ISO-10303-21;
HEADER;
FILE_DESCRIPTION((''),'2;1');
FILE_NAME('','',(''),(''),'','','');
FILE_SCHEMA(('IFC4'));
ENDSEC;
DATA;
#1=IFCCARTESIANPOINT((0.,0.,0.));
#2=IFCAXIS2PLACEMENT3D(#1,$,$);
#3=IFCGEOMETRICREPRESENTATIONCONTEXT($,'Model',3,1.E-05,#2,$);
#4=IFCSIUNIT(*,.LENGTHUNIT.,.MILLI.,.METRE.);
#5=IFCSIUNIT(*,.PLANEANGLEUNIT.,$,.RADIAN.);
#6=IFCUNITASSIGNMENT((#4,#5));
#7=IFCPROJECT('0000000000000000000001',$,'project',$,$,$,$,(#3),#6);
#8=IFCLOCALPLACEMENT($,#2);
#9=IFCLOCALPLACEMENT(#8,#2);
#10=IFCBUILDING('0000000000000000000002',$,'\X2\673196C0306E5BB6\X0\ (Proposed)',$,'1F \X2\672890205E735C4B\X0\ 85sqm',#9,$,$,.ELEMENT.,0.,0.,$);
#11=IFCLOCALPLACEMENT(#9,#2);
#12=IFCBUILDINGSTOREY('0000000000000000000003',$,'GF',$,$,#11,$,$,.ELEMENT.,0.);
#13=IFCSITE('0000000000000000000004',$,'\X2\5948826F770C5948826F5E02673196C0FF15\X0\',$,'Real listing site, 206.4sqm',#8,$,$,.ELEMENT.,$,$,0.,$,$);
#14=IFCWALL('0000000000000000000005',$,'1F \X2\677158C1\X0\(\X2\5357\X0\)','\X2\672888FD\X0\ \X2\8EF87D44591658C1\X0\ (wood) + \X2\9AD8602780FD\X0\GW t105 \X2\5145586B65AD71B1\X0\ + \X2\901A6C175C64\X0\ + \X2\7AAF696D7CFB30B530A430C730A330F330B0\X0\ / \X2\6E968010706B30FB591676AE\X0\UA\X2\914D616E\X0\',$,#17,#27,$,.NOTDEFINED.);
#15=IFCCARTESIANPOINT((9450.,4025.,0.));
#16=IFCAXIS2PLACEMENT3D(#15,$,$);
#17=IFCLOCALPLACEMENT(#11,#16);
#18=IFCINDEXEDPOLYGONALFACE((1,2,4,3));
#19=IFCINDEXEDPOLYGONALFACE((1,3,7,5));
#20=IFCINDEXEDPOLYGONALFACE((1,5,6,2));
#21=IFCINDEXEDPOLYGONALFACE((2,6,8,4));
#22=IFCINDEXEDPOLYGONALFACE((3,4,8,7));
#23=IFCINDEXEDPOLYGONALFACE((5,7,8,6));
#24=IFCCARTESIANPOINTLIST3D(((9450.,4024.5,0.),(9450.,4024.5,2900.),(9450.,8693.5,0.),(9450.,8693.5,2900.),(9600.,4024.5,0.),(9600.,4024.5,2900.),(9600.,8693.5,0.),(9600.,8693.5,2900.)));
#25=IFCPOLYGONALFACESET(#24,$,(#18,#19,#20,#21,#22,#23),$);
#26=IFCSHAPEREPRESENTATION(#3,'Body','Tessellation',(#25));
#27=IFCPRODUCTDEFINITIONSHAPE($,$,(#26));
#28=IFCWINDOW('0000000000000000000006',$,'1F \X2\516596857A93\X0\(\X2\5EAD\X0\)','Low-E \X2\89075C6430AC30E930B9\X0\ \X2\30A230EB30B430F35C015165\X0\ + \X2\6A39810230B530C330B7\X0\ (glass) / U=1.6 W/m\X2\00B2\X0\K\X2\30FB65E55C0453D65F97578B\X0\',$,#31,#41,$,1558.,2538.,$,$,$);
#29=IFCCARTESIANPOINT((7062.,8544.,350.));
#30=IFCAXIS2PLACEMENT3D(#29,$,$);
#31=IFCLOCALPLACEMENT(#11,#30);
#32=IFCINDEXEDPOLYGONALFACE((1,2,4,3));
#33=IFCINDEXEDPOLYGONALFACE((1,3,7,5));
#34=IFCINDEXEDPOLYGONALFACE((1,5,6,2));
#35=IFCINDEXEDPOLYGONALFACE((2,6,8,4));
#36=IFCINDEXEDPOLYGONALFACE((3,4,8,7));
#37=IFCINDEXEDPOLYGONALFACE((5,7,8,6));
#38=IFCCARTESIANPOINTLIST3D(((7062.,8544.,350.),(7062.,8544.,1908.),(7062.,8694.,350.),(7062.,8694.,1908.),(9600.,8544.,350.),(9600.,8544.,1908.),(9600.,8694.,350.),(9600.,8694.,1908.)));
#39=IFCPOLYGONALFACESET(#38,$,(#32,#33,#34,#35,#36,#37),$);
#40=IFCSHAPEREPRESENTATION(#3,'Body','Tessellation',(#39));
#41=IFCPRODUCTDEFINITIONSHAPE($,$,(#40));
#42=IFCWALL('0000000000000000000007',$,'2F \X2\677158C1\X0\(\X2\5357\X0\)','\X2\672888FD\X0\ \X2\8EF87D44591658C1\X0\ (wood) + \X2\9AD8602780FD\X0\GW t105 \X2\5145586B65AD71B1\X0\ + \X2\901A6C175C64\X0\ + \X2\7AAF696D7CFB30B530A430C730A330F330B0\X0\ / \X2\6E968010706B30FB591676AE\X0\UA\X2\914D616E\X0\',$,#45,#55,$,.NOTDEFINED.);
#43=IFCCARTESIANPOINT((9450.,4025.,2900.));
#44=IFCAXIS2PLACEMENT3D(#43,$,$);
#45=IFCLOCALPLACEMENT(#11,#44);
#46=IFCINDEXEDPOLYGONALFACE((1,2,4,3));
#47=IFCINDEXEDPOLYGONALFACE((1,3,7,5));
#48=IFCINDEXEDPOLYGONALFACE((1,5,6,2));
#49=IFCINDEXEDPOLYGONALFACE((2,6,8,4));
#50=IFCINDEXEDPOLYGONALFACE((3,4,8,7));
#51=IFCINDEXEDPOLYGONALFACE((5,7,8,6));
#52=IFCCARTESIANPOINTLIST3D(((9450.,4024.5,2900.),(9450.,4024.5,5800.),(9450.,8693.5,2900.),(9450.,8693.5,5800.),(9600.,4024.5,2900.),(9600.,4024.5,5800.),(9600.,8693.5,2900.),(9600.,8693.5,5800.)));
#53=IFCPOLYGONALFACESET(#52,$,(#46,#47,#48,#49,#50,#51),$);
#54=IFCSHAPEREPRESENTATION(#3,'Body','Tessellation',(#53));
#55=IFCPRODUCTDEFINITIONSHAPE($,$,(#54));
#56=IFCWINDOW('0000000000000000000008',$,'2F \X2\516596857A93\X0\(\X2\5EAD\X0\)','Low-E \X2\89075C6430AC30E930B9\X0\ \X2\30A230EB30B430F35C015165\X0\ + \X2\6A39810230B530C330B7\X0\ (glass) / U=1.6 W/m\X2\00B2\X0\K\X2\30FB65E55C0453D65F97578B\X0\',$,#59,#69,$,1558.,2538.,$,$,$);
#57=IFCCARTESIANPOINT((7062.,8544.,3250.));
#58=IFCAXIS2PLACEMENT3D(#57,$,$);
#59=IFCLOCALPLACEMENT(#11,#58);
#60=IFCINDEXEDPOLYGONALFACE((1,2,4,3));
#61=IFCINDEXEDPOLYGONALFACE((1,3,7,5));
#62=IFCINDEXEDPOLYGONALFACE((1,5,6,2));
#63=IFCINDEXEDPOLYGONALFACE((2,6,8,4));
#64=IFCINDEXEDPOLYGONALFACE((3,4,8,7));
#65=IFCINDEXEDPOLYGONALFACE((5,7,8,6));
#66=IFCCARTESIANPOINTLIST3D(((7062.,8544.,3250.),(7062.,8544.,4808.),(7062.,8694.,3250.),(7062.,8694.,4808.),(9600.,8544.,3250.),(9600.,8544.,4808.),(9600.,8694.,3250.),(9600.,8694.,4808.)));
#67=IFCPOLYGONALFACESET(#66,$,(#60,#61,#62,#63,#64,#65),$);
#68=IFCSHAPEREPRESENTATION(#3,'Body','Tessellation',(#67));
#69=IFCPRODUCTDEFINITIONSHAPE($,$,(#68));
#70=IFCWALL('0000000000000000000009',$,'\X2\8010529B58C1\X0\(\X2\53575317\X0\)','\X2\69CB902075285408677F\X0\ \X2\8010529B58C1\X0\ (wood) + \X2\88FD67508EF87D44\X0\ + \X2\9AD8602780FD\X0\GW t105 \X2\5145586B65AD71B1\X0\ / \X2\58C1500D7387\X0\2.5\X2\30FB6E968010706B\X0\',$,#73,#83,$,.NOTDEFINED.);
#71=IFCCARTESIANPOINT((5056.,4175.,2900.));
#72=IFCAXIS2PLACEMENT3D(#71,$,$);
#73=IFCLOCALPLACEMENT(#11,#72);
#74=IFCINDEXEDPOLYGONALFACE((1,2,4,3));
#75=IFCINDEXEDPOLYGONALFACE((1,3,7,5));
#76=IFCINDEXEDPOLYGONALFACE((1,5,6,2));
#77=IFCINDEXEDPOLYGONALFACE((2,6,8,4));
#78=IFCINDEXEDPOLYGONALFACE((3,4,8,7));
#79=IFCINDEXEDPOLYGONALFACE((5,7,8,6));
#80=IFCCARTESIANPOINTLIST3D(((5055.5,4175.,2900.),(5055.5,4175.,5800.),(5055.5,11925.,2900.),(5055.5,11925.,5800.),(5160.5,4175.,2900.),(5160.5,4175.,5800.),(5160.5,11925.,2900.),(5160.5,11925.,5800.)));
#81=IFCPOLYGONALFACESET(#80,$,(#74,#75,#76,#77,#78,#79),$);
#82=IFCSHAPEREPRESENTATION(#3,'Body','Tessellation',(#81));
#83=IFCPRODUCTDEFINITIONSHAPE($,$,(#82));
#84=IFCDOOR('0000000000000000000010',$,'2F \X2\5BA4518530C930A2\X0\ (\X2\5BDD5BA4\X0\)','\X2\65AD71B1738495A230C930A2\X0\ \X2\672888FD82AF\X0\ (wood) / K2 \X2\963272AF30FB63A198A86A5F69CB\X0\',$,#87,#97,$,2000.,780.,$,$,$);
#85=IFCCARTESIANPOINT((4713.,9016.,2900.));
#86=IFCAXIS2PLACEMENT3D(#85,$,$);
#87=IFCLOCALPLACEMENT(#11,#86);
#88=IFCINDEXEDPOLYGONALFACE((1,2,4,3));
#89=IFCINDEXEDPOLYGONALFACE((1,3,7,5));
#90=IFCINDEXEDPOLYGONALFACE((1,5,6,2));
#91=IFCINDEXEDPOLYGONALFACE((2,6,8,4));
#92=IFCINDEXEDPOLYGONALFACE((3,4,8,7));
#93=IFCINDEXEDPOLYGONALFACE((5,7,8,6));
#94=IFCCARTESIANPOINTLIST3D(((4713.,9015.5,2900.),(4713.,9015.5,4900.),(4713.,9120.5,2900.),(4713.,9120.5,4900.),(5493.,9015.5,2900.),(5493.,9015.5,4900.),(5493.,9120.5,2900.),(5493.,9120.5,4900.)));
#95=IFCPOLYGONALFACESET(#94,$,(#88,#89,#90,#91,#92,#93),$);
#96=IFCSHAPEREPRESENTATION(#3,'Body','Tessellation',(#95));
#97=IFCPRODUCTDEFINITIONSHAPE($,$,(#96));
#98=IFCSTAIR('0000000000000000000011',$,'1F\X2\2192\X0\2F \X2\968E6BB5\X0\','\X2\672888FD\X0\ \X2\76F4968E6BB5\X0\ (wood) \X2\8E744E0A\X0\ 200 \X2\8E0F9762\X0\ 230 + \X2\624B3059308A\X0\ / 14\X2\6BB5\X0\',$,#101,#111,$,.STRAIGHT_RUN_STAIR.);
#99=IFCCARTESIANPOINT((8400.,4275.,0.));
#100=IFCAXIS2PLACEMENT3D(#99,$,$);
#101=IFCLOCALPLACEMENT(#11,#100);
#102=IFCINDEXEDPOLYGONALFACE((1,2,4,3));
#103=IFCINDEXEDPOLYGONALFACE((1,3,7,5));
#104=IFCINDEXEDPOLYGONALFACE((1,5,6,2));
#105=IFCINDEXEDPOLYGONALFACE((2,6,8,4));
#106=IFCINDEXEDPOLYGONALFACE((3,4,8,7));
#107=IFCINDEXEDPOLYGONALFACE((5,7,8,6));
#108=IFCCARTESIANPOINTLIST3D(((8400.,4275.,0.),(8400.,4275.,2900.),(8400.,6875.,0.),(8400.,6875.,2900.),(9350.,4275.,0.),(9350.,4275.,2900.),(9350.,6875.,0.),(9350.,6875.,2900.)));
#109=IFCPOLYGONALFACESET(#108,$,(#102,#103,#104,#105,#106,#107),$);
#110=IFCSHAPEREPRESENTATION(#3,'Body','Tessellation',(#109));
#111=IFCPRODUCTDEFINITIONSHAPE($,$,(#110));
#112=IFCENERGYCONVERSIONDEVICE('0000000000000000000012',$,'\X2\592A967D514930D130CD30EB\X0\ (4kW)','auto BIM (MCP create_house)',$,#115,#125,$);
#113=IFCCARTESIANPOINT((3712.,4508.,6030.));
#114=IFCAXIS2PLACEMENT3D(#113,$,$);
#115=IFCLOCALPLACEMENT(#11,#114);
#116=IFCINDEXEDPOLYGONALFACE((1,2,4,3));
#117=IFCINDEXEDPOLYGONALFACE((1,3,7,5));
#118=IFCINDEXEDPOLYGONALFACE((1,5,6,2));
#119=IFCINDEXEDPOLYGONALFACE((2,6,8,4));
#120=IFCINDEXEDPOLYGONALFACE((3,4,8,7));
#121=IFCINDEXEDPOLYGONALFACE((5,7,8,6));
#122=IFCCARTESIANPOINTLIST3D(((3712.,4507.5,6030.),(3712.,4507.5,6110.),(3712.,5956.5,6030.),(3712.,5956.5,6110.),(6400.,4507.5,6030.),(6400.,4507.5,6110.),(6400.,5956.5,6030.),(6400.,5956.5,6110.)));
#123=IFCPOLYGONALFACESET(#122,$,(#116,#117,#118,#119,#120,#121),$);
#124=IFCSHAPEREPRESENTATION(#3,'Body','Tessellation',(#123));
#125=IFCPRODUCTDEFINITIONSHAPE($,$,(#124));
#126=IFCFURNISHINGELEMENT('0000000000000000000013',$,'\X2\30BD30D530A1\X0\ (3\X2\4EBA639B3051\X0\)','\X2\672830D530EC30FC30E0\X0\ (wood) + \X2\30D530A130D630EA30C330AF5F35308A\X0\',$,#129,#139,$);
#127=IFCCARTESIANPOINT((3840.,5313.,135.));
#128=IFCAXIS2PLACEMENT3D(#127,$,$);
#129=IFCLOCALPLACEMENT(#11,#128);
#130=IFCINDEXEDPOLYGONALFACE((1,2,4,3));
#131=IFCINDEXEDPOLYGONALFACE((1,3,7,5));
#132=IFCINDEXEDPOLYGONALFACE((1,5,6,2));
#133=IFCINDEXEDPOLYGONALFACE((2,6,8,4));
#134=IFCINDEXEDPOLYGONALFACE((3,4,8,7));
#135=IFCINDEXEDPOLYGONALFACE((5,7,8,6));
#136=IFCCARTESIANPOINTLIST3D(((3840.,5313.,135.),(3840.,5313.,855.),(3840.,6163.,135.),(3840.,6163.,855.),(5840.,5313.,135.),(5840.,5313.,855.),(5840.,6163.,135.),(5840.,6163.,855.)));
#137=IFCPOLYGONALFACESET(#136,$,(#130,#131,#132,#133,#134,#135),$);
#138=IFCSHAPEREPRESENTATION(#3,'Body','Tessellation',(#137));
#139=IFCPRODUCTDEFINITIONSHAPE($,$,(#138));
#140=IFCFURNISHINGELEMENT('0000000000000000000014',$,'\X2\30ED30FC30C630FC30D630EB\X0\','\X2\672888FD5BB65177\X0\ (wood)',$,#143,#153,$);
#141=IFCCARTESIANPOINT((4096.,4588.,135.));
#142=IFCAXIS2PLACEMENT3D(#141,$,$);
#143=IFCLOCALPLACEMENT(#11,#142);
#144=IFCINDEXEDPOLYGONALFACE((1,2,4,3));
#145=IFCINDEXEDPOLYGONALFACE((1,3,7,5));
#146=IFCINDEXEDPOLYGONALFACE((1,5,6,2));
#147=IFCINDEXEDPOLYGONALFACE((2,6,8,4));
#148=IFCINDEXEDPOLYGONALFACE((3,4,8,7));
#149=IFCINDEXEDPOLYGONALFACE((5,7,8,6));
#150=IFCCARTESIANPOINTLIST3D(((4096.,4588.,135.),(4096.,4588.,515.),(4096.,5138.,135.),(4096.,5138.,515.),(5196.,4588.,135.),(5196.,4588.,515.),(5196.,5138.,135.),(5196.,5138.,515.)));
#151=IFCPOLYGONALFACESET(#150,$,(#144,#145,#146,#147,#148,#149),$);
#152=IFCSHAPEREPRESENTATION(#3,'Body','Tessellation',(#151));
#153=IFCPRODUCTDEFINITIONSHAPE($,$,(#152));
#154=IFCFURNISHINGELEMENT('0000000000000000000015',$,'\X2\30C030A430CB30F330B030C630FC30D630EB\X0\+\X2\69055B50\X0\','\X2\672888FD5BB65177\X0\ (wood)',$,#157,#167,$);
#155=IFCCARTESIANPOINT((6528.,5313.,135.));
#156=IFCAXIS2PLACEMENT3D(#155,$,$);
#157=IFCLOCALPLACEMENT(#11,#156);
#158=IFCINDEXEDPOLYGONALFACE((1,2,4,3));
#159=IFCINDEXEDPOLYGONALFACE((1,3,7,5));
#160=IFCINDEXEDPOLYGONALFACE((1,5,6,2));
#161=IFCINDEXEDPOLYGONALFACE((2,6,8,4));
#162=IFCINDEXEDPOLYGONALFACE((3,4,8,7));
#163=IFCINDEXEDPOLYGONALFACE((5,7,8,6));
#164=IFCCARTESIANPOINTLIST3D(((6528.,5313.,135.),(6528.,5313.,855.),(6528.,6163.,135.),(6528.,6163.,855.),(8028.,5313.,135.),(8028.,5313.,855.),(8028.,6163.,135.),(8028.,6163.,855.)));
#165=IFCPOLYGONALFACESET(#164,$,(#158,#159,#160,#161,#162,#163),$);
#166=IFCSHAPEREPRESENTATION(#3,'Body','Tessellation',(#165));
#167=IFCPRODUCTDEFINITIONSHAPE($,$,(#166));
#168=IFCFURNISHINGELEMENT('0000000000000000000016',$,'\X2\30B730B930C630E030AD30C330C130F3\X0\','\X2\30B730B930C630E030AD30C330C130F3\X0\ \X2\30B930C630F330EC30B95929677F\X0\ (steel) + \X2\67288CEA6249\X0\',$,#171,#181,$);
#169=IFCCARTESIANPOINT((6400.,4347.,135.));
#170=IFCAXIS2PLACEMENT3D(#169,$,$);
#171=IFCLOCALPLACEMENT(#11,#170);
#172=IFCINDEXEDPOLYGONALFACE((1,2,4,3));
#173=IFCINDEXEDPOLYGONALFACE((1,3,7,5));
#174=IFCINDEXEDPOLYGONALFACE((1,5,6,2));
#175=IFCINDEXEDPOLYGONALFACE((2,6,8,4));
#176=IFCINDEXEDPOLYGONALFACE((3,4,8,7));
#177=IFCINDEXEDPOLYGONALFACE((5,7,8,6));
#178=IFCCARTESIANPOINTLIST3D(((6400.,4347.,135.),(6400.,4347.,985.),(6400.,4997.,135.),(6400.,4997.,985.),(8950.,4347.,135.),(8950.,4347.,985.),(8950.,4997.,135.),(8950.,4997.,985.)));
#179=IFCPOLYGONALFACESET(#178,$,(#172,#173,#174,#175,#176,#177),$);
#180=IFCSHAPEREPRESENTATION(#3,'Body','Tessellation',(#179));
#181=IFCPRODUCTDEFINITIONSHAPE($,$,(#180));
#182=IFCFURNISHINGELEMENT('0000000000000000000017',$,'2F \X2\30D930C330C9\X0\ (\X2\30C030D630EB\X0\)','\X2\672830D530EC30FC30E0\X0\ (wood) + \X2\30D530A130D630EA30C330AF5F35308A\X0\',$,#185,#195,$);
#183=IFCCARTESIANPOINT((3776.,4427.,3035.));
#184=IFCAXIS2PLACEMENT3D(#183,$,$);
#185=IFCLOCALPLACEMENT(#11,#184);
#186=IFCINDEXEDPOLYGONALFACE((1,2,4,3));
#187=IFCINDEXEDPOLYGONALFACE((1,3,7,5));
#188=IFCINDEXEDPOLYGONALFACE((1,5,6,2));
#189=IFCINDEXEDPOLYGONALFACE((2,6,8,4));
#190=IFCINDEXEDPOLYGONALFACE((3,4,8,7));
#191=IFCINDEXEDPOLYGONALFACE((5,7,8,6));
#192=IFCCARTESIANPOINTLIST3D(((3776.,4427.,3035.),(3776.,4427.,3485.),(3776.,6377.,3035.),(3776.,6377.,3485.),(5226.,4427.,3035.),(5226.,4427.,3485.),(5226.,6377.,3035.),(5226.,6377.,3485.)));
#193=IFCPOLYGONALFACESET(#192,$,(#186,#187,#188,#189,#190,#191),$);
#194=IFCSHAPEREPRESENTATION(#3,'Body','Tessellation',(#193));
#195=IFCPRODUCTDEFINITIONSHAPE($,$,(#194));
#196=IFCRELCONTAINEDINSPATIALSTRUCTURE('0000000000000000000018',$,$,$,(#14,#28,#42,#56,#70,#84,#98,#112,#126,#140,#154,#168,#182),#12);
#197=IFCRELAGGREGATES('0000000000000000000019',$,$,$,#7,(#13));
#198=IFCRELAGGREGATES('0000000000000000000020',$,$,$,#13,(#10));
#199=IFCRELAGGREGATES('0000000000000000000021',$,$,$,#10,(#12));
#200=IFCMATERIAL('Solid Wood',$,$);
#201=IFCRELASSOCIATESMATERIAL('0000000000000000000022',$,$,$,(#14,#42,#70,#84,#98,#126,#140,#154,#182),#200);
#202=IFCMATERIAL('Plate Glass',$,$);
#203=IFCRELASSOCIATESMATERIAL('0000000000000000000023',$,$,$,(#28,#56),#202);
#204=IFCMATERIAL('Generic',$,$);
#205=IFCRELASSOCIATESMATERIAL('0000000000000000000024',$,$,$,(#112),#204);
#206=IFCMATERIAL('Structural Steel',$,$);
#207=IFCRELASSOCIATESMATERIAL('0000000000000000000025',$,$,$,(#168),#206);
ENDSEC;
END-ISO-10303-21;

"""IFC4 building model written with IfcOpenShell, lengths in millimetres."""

from ifc_helpers import new_model, si_unit, frame, frame_2d, origin, place, context, project, spatial, rectangle, extrude, material, element, fill, save


model = new_model("IFC4")

# Units and contexts
model_context = context("Model", 3, precision=1e-05, world=origin())
ifc_project = project(units=[si_unit("LENGTHUNIT", "METRE", prefix="MILLI"), si_unit("PLANEANGLEUNIT", "RADIAN")], contexts=[model_context])

# Site, building, storey
site_placement = place(None, origin())
site = spatial("IfcSite", under=ifc_project, at=site_placement, Name="奈良県奈良市朱雀５", ObjectType="Real listing site, 206.4sqm", CompositionType="ELEMENT", RefElevation=0.0)
building_placement = place(site_placement, origin())
building = spatial("IfcBuilding", under=site, at=building_placement, Name="朱雀の家 (Proposed)", ObjectType="1F 木造平屋 85sqm", CompositionType="ELEMENT", ElevationOfRefHeight=0.0, ElevationOfTerrain=0.0)
storey_placement = place(building_placement, origin())
storey = spatial("IfcBuildingStorey", under=building, at=storey_placement, Name="GF", CompositionType="ELEMENT", Elevation=0.0)

# Wall, opening, window
ifc_material_1 = material(Name="Solid Wood")
wall_1_placement = place(storey_placement, frame((9450.0, 4025.0, 0.0)))
wall_1 = element("IfcWall", 1, at=wall_1_placement, inside=storey, material=ifc_material_1, Name="1F 東壁(南)", Description="木製 軸組外壁 (wood) + 高性能GW t105 充填断熱 + 通気層 + 窯業系サイディング / 準耐火・外皮UA配慮", PredefinedType="NOTDEFINED", context=model_context, shape_type="SweptSolid", body=[
    extrude(rectangle(XDim=150.0, YDim=4669.0, at=frame_2d((75.0, 2334.0))), frame((9450.0, 4025.0, 0.0)), (0.0, 0.0, 1.0), 2900.0),
])
opening_1_placement = place(storey_placement, frame((7062.0, 8544.0, 350.0)))
opening_1 = element("IfcOpeningElement", 2, at=opening_1_placement, cuts=wall_1, PredefinedType="NOTDEFINED", context=model_context, shape_type="SweptSolid", body=[
    extrude(rectangle(XDim=2538.0, YDim=150.0, at=frame_2d((1269.0, 75.0))), frame((7062.0, 8544.0, 350.0)), (0.0, 0.0, 1.0), 1558.0),
])
ifc_material_2 = material(Name="Plate Glass")
window_1_placement = place(storey_placement, frame((7062.0, 8544.0, 350.0)))
window_1 = element("IfcWindow", 3, at=window_1_placement, inside=storey, material=ifc_material_2, Name="1F 入隅窓(庭)", Description="Low-E 複層ガラス アルゴン封入 + 樹脂サッシ (glass) / U=1.6 W/m²K・日射取得型", OverallHeight=1558.0, OverallWidth=2538.0, context=model_context, shape_type="SweptSolid", body=[
    extrude(rectangle(XDim=2538.0, YDim=150.0, at=frame_2d((1269.0, 75.0))), frame((7062.0, 8544.0, 350.0)), (0.0, 0.0, 1.0), 1558.0),
])
fill(opening_1, window_1)

# Wall, opening, window
wall_2_placement = place(storey_placement, frame((9450.0, 4025.0, 2900.0)))
wall_2 = element("IfcWall", 4, at=wall_2_placement, inside=storey, material=ifc_material_1, Name="2F 東壁(南)", Description="木製 軸組外壁 (wood) + 高性能GW t105 充填断熱 + 通気層 + 窯業系サイディング / 準耐火・外皮UA配慮", PredefinedType="NOTDEFINED", context=model_context, shape_type="SweptSolid", body=[
    extrude(rectangle(XDim=150.0, YDim=4669.0, at=frame_2d((75.0, 2334.0))), frame((9450.0, 4025.0, 2900.0)), (0.0, 0.0, 1.0), 2900.0),
])
opening_2_placement = place(storey_placement, frame((7062.0, 8544.0, 3250.0)))
opening_2 = element("IfcOpeningElement", 5, at=opening_2_placement, cuts=wall_2, PredefinedType="NOTDEFINED", context=model_context, shape_type="SweptSolid", body=[
    extrude(rectangle(XDim=2538.0, YDim=150.0, at=frame_2d((1269.0, 75.0))), frame((7062.0, 8544.0, 3250.0)), (0.0, 0.0, 1.0), 1558.0),
])
window_2_placement = place(storey_placement, frame((7062.0, 8544.0, 3250.0)))
window_2 = element("IfcWindow", 6, at=window_2_placement, inside=storey, material=ifc_material_2, Name="2F 入隅窓(庭)", Description="Low-E 複層ガラス アルゴン封入 + 樹脂サッシ (glass) / U=1.6 W/m²K・日射取得型", OverallHeight=1558.0, OverallWidth=2538.0, context=model_context, shape_type="SweptSolid", body=[
    extrude(rectangle(XDim=2538.0, YDim=150.0, at=frame_2d((1269.0, 75.0))), frame((7062.0, 8544.0, 3250.0)), (0.0, 0.0, 1.0), 1558.0),
])
fill(opening_2, window_2)

# Wall, opening, door
wall_3_placement = place(storey_placement, frame((5056.0, 4175.0, 2900.0)))
wall_3 = element("IfcWall", 7, at=wall_3_placement, inside=storey, material=ifc_material_1, Name="耐力壁(南北)", Description="構造用合板 耐力壁 (wood) + 製材軸組 + 高性能GW t105 充填断熱 / 壁倍率2.5・準耐火", PredefinedType="NOTDEFINED", context=model_context, shape_type="SweptSolid", body=[
    extrude(rectangle(XDim=105.0, YDim=7750.0, at=frame_2d((52.0, 3875.0))), frame((5056.0, 4175.0, 2900.0)), (0.0, 0.0, 1.0), 2900.0),
])
opening_3_placement = place(storey_placement, frame((4713.0, 9016.0, 2900.0)))
opening_3 = element("IfcOpeningElement", 8, at=opening_3_placement, cuts=wall_3, PredefinedType="NOTDEFINED", context=model_context, shape_type="SweptSolid", body=[
    extrude(rectangle(XDim=780.0, YDim=105.0, at=frame_2d((390.0, 52.0))), frame((4713.0, 9016.0, 2900.0)), (0.0, 0.0, 1.0), 2000.0),
])
door_1_placement = place(storey_placement, frame((4713.0, 9016.0, 2900.0)))
door_1 = element("IfcDoor", 9, at=door_1_placement, inside=storey, material=ifc_material_1, Name="2F 室内ドア (寝室)", Description="断熱玄関ドア 木製芯 (wood) / K2 防犯・採風機構", OverallHeight=2000.0, OverallWidth=780.0, context=model_context, shape_type="SweptSolid", body=[
    extrude(rectangle(XDim=780.0, YDim=105.0, at=frame_2d((390.0, 52.0))), frame((4713.0, 9016.0, 2900.0)), (0.0, 0.0, 1.0), 2000.0),
])
fill(opening_3, door_1)

# Stair
stair_placement = place(storey_placement, frame((8400.0, 4275.0, 0.0)))
element("IfcStair", 10, at=stair_placement, inside=storey, material=ifc_material_1, Name="1F→2F 階段", Description="木製 直階段 (wood) 蹴上 200 踏面 230 + 手すり / 14段", PredefinedType="STRAIGHT_RUN_STAIR", context=model_context, shape_type="SweptSolid", body=[
    extrude(rectangle(XDim=950.0, YDim=2600.0, at=frame_2d((475.0, 1300.0))), frame((8400.0, 4275.0, 0.0)), (0.0, 0.0, 1.0), 2900.0),
])

# Energy conversion device
ifc_material_3 = material(Name="Generic")
energy_conversion_device_placement = place(storey_placement, frame((3712.0, 4508.0, 6030.0)))
element("IfcEnergyConversionDevice", 11, at=energy_conversion_device_placement, inside=storey, material=ifc_material_3, Name="太陽光パネル (4kW)", Description="auto BIM (MCP create_house)", context=model_context, shape_type="SweptSolid", body=[
    extrude(rectangle(XDim=2688.0, YDim=1449.0, at=frame_2d((1344.0, 724.0))), frame((3712.0, 4508.0, 6030.0)), (0.0, 0.0, 1.0), 80.0),
])

# Furnishing elements
furnishing_1_placement = place(storey_placement, frame((3840.0, 5313.0, 135.0)))
element("IfcFurnishingElement", 12, at=furnishing_1_placement, inside=storey, material=ifc_material_1, Name="ソファ (3人掛け)", Description="木フレーム (wood) + ファブリック張り", context=model_context, shape_type="SweptSolid", body=[
    extrude(rectangle(XDim=2000.0, YDim=850.0, at=frame_2d((1000.0, 425.0))), frame((3840.0, 5313.0, 135.0)), (0.0, 0.0, 1.0), 720.0),
])
furnishing_2_placement = place(storey_placement, frame((4096.0, 4588.0, 135.0)))
element("IfcFurnishingElement", 13, at=furnishing_2_placement, inside=storey, material=ifc_material_1, Name="ローテーブル", Description="木製家具 (wood)", context=model_context, shape_type="SweptSolid", body=[
    extrude(rectangle(XDim=1100.0, YDim=550.0, at=frame_2d((550.0, 275.0))), frame((4096.0, 4588.0, 135.0)), (0.0, 0.0, 1.0), 380.0),
])
furnishing_3_placement = place(storey_placement, frame((6528.0, 5313.0, 135.0)))
element("IfcFurnishingElement", 14, at=furnishing_3_placement, inside=storey, material=ifc_material_1, Name="ダイニングテーブル+椅子", Description="木製家具 (wood)", context=model_context, shape_type="SweptSolid", body=[
    extrude(rectangle(XDim=1500.0, YDim=850.0, at=frame_2d((750.0, 425.0))), frame((6528.0, 5313.0, 135.0)), (0.0, 0.0, 1.0), 720.0),
])
ifc_material_4 = material(Name="Structural Steel")
furnishing_4_placement = place(storey_placement, frame((6400.0, 4347.0, 135.0)))
element("IfcFurnishingElement", 15, at=furnishing_4_placement, inside=storey, material=ifc_material_4, Name="システムキッチン", Description="システムキッチン ステンレス天板 (steel) + 木質扉", context=model_context, shape_type="SweptSolid", body=[
    extrude(rectangle(XDim=2550.0, YDim=650.0, at=frame_2d((1275.0, 325.0))), frame((6400.0, 4347.0, 135.0)), (0.0, 0.0, 1.0), 850.0),
])
furnishing_5_placement = place(storey_placement, frame((3776.0, 4427.0, 3035.0)))
element("IfcFurnishingElement", 16, at=furnishing_5_placement, inside=storey, material=ifc_material_1, Name="2F ベッド (ダブル)", Description="木フレーム (wood) + ファブリック張り", context=model_context, shape_type="SweptSolid", body=[
    extrude(rectangle(XDim=1450.0, YDim=1950.0, at=frame_2d((725.0, 975.0))), frame((3776.0, 4427.0, 3035.0)), (0.0, 0.0, 1.0), 450.0),
])

save(model, "model.ifc")
